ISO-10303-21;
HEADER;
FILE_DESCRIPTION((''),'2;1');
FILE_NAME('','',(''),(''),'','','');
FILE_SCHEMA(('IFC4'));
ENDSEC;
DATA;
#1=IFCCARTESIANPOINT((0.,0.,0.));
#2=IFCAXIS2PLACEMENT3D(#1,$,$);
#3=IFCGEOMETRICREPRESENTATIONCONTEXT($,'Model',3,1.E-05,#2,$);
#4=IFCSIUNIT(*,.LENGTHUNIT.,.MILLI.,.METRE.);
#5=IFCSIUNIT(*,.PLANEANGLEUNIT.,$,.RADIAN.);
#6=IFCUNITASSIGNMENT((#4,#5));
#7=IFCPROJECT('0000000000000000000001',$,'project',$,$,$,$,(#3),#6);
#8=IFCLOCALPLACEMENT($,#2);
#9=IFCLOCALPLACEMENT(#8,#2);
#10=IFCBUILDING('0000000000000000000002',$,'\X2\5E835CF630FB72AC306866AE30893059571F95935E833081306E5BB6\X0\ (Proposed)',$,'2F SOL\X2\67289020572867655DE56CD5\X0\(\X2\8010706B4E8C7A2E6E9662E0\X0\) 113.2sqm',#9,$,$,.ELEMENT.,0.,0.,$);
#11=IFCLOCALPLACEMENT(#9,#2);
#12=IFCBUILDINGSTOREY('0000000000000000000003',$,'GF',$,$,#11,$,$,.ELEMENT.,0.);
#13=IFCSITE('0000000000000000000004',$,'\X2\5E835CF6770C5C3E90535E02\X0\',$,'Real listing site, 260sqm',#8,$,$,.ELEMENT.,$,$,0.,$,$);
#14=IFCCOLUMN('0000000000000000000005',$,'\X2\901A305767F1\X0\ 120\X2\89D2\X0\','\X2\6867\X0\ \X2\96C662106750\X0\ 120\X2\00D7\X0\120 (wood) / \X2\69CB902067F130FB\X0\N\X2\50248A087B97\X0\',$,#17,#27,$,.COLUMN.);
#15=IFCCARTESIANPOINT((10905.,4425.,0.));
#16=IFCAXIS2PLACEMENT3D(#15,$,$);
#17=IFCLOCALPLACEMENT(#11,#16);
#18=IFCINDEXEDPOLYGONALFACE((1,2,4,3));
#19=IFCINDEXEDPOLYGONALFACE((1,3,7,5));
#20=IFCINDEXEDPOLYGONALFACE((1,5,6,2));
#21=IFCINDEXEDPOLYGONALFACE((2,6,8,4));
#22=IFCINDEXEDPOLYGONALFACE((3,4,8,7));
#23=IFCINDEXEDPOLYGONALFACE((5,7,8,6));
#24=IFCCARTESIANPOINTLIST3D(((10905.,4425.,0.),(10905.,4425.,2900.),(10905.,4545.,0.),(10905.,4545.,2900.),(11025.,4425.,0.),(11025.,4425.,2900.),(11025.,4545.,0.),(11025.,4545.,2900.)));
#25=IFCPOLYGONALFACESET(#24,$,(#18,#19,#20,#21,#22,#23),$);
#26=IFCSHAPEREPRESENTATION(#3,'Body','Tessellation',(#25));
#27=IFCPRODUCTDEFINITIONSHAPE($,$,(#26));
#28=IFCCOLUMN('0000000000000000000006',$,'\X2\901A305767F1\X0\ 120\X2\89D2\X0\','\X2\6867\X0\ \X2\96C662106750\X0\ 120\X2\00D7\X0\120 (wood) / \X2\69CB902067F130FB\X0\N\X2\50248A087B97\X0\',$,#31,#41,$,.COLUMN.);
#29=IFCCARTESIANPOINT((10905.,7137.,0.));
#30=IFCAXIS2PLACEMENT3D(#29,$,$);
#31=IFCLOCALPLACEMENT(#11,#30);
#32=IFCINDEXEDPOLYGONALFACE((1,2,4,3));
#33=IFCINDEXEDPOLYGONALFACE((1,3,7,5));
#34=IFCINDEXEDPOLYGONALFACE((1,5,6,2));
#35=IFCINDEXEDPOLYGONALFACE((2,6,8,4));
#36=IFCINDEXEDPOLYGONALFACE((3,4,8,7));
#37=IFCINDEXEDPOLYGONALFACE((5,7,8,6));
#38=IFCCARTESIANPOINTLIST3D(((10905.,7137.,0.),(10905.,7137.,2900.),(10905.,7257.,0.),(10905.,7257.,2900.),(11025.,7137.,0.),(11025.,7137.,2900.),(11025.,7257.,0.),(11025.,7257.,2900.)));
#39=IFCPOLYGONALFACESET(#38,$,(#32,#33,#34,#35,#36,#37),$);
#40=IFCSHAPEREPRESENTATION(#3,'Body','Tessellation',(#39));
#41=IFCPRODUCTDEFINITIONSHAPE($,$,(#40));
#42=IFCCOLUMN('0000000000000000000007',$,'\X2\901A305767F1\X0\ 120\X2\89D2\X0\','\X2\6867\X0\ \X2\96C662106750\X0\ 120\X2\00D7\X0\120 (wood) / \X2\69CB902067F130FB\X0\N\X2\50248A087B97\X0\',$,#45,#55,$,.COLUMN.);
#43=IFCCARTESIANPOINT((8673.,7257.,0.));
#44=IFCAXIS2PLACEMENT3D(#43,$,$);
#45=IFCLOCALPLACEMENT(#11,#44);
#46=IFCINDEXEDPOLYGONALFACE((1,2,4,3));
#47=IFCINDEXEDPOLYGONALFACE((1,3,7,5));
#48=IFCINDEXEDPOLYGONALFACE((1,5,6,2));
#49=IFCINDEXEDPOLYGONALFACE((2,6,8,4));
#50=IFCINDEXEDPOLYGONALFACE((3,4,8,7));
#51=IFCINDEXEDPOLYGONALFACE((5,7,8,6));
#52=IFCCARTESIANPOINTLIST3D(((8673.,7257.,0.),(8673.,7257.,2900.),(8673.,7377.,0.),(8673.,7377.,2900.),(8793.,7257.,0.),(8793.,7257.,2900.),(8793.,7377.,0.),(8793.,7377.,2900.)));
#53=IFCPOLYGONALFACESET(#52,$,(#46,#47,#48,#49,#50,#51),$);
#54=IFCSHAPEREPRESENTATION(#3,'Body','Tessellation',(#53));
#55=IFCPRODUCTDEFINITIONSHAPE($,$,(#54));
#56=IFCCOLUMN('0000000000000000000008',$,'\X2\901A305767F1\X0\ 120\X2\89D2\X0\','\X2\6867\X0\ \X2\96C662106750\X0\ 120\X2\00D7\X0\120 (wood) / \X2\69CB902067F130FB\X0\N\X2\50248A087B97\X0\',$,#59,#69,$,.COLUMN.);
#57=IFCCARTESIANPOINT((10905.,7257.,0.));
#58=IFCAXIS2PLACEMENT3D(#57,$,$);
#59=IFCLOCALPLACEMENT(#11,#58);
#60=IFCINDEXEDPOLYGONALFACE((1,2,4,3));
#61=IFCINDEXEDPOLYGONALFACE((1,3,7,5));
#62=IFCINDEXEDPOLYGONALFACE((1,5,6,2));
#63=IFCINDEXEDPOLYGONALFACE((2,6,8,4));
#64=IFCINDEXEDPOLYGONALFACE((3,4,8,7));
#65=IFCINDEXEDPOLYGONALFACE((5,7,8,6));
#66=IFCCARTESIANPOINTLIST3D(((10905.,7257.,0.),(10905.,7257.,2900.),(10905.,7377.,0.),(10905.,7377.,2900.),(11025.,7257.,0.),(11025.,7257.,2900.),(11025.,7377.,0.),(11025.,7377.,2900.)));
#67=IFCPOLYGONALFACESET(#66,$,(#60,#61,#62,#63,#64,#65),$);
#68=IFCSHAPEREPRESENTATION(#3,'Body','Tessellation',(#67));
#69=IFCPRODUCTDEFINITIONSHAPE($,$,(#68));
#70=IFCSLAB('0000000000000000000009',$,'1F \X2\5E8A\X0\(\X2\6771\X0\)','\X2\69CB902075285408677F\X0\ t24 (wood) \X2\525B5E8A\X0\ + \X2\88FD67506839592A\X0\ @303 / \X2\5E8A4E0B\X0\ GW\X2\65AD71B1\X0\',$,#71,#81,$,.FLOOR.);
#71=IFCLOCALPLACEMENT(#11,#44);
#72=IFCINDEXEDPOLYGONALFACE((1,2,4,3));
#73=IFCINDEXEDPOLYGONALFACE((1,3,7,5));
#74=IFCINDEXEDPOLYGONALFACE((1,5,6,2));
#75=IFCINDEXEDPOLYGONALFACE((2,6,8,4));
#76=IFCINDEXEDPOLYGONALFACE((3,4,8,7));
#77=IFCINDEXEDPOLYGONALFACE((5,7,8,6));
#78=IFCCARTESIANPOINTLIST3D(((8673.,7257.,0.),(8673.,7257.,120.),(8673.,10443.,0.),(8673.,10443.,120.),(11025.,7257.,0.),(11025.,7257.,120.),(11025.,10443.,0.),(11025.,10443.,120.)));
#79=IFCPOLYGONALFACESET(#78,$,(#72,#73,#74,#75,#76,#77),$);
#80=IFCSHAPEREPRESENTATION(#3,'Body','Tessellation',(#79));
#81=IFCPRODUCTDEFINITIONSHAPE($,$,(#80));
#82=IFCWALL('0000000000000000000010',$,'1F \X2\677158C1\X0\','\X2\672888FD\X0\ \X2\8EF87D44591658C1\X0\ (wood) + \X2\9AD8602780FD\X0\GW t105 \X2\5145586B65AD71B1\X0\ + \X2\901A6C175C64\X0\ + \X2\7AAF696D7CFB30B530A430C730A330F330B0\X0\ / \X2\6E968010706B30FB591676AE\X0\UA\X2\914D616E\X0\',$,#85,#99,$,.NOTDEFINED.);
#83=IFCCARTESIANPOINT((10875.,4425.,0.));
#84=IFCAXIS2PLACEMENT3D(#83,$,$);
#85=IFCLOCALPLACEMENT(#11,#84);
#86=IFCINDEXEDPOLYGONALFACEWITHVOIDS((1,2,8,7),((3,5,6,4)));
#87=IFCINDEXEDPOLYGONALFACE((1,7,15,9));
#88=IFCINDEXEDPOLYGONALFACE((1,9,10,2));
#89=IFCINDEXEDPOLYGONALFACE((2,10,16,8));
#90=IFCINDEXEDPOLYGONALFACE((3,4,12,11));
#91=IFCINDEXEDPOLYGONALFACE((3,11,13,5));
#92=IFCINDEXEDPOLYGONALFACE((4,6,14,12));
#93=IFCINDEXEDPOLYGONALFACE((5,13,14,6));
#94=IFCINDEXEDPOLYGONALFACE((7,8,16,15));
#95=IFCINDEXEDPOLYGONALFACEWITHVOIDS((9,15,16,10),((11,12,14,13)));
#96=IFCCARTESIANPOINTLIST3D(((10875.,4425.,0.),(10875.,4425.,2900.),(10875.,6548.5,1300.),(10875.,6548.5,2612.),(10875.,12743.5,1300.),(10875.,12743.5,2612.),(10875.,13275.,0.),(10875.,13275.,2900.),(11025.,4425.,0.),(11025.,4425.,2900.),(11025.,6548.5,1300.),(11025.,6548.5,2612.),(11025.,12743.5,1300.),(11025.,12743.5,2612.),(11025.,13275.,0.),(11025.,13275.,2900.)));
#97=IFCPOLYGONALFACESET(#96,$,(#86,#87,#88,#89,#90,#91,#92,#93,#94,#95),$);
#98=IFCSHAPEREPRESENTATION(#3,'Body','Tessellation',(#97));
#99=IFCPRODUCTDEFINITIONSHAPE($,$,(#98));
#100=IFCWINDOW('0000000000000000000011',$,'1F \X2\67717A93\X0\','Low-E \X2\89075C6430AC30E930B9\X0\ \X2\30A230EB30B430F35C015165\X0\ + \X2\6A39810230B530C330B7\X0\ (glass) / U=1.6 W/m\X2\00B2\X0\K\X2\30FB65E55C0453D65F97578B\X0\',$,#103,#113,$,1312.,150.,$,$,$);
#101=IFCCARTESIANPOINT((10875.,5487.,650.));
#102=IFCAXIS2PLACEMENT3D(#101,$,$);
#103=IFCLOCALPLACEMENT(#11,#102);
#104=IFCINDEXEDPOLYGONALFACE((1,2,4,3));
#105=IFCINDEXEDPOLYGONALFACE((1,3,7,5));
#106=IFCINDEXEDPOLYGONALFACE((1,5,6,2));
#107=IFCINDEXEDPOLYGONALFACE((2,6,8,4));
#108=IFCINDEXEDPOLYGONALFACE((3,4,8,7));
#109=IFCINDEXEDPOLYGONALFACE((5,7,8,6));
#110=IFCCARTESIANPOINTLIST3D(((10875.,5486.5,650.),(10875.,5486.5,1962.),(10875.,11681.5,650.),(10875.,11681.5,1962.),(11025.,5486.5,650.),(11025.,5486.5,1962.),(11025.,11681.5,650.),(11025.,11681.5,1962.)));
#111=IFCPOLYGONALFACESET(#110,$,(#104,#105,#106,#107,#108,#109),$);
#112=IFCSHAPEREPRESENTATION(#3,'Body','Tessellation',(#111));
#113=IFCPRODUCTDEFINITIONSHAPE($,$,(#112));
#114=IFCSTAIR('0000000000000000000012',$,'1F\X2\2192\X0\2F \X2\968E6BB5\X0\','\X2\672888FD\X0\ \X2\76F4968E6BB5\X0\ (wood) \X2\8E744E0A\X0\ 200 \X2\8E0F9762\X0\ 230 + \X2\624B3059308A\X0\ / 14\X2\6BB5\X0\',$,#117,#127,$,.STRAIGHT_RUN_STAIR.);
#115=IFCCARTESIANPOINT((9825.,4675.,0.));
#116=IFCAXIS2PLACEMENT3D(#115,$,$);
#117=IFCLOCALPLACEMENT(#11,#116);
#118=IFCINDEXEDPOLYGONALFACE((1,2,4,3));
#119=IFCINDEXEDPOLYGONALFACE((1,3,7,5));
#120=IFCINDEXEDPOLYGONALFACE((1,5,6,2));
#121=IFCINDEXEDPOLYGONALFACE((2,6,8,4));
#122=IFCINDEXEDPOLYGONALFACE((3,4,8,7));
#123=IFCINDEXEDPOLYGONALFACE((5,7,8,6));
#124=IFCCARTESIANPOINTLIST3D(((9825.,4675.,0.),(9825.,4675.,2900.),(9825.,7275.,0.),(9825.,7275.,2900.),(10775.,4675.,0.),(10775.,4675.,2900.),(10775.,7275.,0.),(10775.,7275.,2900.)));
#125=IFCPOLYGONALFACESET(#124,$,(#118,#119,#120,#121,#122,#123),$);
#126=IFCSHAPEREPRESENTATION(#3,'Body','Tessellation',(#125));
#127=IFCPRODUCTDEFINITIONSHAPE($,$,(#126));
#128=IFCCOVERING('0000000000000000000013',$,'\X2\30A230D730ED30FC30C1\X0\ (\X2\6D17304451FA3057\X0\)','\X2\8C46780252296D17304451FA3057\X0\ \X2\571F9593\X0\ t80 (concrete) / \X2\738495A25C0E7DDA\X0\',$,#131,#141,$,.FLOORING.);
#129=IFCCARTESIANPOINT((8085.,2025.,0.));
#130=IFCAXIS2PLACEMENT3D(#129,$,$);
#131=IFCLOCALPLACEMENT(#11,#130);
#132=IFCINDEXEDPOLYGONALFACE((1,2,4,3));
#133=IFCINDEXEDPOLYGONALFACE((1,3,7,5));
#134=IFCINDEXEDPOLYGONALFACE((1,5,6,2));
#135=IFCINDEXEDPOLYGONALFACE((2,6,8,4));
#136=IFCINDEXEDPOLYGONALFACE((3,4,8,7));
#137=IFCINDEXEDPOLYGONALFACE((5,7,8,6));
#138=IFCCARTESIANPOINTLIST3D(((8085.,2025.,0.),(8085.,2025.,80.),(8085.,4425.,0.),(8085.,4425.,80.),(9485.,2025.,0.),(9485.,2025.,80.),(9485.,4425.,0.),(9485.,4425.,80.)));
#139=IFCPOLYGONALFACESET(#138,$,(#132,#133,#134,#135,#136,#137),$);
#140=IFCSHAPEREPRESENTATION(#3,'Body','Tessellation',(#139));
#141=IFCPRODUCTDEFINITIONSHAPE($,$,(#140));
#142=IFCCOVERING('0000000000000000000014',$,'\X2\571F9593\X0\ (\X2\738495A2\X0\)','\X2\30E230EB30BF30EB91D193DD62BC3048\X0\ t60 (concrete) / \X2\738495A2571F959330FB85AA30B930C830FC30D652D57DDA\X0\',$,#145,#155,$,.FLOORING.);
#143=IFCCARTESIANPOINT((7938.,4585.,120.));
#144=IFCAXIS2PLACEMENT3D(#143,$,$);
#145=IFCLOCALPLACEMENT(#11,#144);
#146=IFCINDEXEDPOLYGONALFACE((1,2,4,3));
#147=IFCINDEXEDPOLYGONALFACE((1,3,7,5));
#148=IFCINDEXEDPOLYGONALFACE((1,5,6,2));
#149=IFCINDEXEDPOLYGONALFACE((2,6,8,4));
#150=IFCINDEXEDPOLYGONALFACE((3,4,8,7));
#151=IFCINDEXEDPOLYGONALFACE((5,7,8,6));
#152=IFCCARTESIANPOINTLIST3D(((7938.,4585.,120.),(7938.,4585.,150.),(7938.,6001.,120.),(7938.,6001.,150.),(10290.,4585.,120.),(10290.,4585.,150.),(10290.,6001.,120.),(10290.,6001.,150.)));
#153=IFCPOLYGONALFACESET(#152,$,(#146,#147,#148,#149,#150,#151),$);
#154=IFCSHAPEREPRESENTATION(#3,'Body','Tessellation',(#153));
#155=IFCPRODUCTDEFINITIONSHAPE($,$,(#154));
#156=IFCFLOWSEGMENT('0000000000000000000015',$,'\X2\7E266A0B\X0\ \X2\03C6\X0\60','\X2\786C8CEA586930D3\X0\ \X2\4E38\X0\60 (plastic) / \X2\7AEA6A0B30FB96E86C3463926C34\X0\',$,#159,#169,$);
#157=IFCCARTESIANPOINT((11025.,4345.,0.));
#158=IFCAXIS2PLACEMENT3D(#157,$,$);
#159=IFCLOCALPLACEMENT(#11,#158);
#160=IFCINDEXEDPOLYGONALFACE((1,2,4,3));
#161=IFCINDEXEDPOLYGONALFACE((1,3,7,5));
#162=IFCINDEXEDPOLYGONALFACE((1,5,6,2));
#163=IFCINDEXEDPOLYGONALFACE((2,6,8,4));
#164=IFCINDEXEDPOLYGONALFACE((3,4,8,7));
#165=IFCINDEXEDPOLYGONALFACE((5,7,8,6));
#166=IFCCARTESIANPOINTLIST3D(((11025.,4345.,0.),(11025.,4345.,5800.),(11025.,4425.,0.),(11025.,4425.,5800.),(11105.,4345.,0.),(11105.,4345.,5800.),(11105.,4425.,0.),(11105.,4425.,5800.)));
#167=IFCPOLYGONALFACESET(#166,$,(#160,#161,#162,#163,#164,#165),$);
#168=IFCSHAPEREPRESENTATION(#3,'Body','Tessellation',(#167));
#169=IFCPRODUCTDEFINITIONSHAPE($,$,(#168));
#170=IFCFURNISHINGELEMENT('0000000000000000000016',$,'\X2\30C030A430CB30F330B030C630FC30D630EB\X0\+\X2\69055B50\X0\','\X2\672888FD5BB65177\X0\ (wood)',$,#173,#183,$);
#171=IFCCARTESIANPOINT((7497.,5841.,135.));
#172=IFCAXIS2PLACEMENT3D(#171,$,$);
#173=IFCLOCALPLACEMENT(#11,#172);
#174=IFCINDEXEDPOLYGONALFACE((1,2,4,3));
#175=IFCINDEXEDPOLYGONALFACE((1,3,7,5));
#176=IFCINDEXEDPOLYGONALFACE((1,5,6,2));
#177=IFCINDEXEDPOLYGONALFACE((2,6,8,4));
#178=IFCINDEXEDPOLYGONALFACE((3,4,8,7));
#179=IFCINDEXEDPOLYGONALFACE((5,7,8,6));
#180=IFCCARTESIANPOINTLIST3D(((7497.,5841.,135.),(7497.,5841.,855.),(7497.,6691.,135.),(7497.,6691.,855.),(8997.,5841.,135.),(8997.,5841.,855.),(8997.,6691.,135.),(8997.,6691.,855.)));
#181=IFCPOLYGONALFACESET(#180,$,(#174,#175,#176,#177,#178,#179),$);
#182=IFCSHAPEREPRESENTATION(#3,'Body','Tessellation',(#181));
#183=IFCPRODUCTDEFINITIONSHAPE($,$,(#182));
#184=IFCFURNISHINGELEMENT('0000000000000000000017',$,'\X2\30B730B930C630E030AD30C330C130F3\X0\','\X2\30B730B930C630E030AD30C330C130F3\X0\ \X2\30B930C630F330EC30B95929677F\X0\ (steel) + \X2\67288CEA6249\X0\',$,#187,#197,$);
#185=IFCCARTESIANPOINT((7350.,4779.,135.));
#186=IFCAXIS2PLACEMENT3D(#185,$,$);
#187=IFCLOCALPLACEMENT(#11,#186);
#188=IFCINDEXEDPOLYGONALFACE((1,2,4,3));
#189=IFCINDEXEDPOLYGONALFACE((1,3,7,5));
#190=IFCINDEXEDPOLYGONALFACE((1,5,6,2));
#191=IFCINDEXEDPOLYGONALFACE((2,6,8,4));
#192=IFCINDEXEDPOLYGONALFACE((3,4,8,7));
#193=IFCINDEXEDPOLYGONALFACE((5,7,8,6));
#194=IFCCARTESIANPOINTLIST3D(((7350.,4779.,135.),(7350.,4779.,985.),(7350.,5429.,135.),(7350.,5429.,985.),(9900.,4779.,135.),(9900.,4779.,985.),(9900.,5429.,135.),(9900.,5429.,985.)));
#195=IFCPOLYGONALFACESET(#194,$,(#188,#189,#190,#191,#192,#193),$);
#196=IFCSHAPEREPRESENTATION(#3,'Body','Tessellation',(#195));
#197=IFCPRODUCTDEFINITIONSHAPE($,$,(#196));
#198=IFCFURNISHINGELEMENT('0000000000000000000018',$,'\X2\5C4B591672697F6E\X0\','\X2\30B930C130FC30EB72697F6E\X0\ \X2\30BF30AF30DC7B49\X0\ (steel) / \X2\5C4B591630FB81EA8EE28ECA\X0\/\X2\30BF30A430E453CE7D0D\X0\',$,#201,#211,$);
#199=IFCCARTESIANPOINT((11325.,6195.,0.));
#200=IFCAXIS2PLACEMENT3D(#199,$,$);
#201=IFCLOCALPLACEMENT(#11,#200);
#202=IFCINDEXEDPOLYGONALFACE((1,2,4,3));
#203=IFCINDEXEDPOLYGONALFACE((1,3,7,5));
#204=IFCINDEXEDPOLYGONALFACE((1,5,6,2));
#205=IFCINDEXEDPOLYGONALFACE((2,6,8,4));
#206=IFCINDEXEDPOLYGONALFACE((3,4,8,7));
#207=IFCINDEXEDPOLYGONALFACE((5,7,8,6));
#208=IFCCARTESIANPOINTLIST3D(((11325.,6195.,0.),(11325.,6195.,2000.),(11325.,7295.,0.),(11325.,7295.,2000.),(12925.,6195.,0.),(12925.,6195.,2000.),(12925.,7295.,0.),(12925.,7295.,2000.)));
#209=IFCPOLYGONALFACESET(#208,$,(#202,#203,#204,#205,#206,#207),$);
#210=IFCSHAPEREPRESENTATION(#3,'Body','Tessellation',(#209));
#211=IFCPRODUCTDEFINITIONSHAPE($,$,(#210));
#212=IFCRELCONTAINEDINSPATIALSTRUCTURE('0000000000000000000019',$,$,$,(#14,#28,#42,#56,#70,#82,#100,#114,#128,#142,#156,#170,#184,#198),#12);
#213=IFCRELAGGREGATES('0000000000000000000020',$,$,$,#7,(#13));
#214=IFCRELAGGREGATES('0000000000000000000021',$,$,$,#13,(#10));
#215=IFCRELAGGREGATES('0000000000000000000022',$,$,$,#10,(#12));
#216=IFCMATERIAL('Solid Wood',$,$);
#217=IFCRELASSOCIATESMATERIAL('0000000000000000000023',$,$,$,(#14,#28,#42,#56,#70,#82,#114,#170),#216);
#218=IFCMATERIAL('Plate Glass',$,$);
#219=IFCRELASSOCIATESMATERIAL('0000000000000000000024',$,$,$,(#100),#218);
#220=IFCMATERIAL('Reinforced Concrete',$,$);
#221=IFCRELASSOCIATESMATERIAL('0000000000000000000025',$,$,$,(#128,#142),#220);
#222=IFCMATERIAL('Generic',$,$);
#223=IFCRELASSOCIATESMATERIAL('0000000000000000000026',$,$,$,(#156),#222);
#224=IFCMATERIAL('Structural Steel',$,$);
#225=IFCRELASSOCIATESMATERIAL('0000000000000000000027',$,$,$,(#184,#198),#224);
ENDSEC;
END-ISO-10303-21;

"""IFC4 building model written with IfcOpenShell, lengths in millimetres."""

from ifc_helpers import new_model, si_unit, frame, frame_2d, origin, place, context, project, spatial, rectangle, extrude, material, element, fill, save


model = new_model("IFC4")

# Units and contexts
model_context = context("Model", 3, precision=1e-05, world=origin())
ifc_project = project(units=[si_unit("LENGTHUNIT", "METRE", prefix="MILLI"), si_unit("PLANEANGLEUNIT", "RADIAN")], contexts=[model_context])

# Site, building, storey
site_placement = place(None, origin())
site = spatial("IfcSite", under=ifc_project, at=site_placement, Name="広島県尾道市", ObjectType="Real listing site, 260sqm", CompositionType="ELEMENT", RefElevation=0.0)
building_placement = place(site_placement, origin())
building = spatial("IfcBuilding", under=site, at=building_placement, Name="広島・犬と暮らす土間広めの家 (Proposed)", ObjectType="2F SOL木造在来工法(耐火二種準拠) 113.2sqm", CompositionType="ELEMENT", ElevationOfRefHeight=0.0, ElevationOfTerrain=0.0)
storey_placement = place(building_placement, origin())
storey = spatial("IfcBuildingStorey", under=building, at=storey_placement, Name="GF", CompositionType="ELEMENT", Elevation=0.0)

# Columns
ifc_material_1 = material(Name="Solid Wood")
column_1_placement = place(storey_placement, frame((10905.0, 4425.0, 0.0)))
element("IfcColumn", 1, at=column_1_placement, inside=storey, material=ifc_material_1, Name="通し柱 120角", Description="桧 集成材 120×120 (wood) / 構造柱・N値計算", PredefinedType="COLUMN", context=model_context, shape_type="SweptSolid", body=[
    extrude(rectangle(XDim=120.0, YDim=120.0, at=frame_2d((60.0, 60.0))), frame((10905.0, 4425.0, 0.0)), (0.0, 0.0, 1.0), 2900.0),
])
column_2_placement = place(storey_placement, frame((10905.0, 7137.0, 0.0)))
element("IfcColumn", 2, at=column_2_placement, inside=storey, material=ifc_material_1, Name="通し柱 120角", Description="桧 集成材 120×120 (wood) / 構造柱・N値計算", PredefinedType="COLUMN", context=model_context, shape_type="SweptSolid", body=[
    extrude(rectangle(XDim=120.0, YDim=120.0, at=frame_2d((60.0, 60.0))), frame((10905.0, 7137.0, 0.0)), (0.0, 0.0, 1.0), 2900.0),
])
column_3_placement = place(storey_placement, frame((8673.0, 7257.0, 0.0)))
element("IfcColumn", 3, at=column_3_placement, inside=storey, material=ifc_material_1, Name="通し柱 120角", Description="桧 集成材 120×120 (wood) / 構造柱・N値計算", PredefinedType="COLUMN", context=model_context, shape_type="SweptSolid", body=[
    extrude(rectangle(XDim=120.0, YDim=120.0, at=frame_2d((60.0, 60.0))), frame((8673.0, 7257.0, 0.0)), (0.0, 0.0, 1.0), 2900.0),
])
column_4_placement = place(storey_placement, frame((10905.0, 7257.0, 0.0)))
element("IfcColumn", 4, at=column_4_placement, inside=storey, material=ifc_material_1, Name="通し柱 120角", Description="桧 集成材 120×120 (wood) / 構造柱・N値計算", PredefinedType="COLUMN", context=model_context, shape_type="SweptSolid", body=[
    extrude(rectangle(XDim=120.0, YDim=120.0, at=frame_2d((60.0, 60.0))), frame((10905.0, 7257.0, 0.0)), (0.0, 0.0, 1.0), 2900.0),
])

# Slab
slab_placement = place(storey_placement, frame((8673.0, 7257.0, 0.0)))
element("IfcSlab", 5, at=slab_placement, inside=storey, material=ifc_material_1, Name="1F 床(東)", Description="構造用合板 t24 (wood) 剛床 + 製材根太 @303 / 床下 GW断熱", PredefinedType="FLOOR", context=model_context, shape_type="SweptSolid", body=[
    extrude(rectangle(XDim=2352.0, YDim=3186.0, at=frame_2d((1176.0, 1593.0))), frame((8673.0, 7257.0, 0.0)), (0.0, 0.0, 1.0), 120.0),
])

# Wall, opening, window
wall_1_placement = place(storey_placement, frame((10875.0, 4425.0, 0.0)))
wall_1 = element("IfcWall", 6, at=wall_1_placement, inside=storey, material=ifc_material_1, Name="1F 東壁", Description="木製 軸組外壁 (wood) + 高性能GW t105 充填断熱 + 通気層 + 窯業系サイディング / 準耐火・外皮UA配慮", PredefinedType="NOTDEFINED", context=model_context, shape_type="SweptSolid", body=[
    extrude(rectangle(XDim=150.0, YDim=8850.0, at=frame_2d((75.0, 4425.0))), frame((10875.0, 4425.0, 0.0)), (0.0, 0.0, 1.0), 2900.0),
])
opening_placement = place(storey_placement, frame((10875.0, 5487.0, 650.0)))
opening = element("IfcOpeningElement", 7, at=opening_placement, cuts=wall_1, PredefinedType="NOTDEFINED", context=model_context, shape_type="SweptSolid", body=[
    extrude(rectangle(XDim=150.0, YDim=6195.0, at=frame_2d((75.0, 3097.0))), frame((10875.0, 5487.0, 650.0)), (0.0, 0.0, 1.0), 1312.0),
])
ifc_material_2 = material(Name="Plate Glass")
window_placement = place(storey_placement, frame((10875.0, 5487.0, 650.0)))
window = element("IfcWindow", 8, at=window_placement, inside=storey, material=ifc_material_2, Name="1F 東窓", Description="Low-E 複層ガラス アルゴン封入 + 樹脂サッシ (glass) / U=1.6 W/m²K・日射取得型", OverallHeight=1312.0, OverallWidth=150.0, context=model_context, shape_type="SweptSolid", body=[
    extrude(rectangle(XDim=150.0, YDim=6195.0, at=frame_2d((75.0, 3097.0))), frame((10875.0, 5487.0, 650.0)), (0.0, 0.0, 1.0), 1312.0),
])
fill(opening, window)

# Stair
stair_placement = place(storey_placement, frame((9825.0, 4675.0, 0.0)))
element("IfcStair", 9, at=stair_placement, inside=storey, material=ifc_material_1, Name="1F→2F 階段", Description="木製 直階段 (wood) 蹴上 200 踏面 230 + 手すり / 14段", PredefinedType="STRAIGHT_RUN_STAIR", context=model_context, shape_type="SweptSolid", body=[
    extrude(rectangle(XDim=950.0, YDim=2600.0, at=frame_2d((475.0, 1300.0))), frame((9825.0, 4675.0, 0.0)), (0.0, 0.0, 1.0), 2900.0),
])

# Coverings
ifc_material_3 = material(Name="Reinforced Concrete")
covering_1_placement = place(storey_placement, frame((8085.0, 2025.0, 0.0)))
element("IfcCovering", 10, at=covering_1_placement, inside=storey, material=ifc_material_3, Name="アプローチ (洗い出し)", Description="豆砂利洗い出し 土間 t80 (concrete) / 玄関導線", PredefinedType="FLOORING", context=model_context, shape_type="SweptSolid", body=[
    extrude(rectangle(XDim=1400.0, YDim=2400.0, at=frame_2d((700.0, 1200.0))), frame((8085.0, 2025.0, 0.0)), (0.0, 0.0, 1.0), 80.0),
])
covering_2_placement = place(storey_placement, frame((7938.0, 4585.0, 120.0)))
element("IfcCovering", 11, at=covering_2_placement, inside=storey, material=ifc_material_3, Name="土間 (玄関)", Description="モルタル金鏝押え t60 (concrete) / 玄関土間・薪ストーブ動線", PredefinedType="FLOORING", context=model_context, shape_type="SweptSolid", body=[
    extrude(rectangle(XDim=2352.0, YDim=1416.0, at=frame_2d((1176.0, 708.0))), frame((7938.0, 4585.0, 120.0)), (0.0, 0.0, 1.0), 30.0),
])

# Flow segment
ifc_material_4 = material(Name="Generic")
flow_segment_placement = place(storey_placement, frame((11025.0, 4345.0, 0.0)))
element("IfcFlowSegment", 12, at=flow_segment_placement, inside=storey, material=ifc_material_4, Name="縦樋 φ60", Description="硬質塩ビ 丸60 (plastic) / 竪樋・雨水排水", context=model_context, shape_type="SweptSolid", body=[
    extrude(rectangle(XDim=80.0, YDim=80.0, at=frame_2d((40.0, 40.0))), frame((11025.0, 4345.0, 0.0)), (0.0, 0.0, 1.0), 5800.0),
])

# Furnishing elements
furnishing_1_placement = place(storey_placement, frame((7497.0, 5841.0, 135.0)))
element("IfcFurnishingElement", 13, at=furnishing_1_placement, inside=storey, material=ifc_material_1, Name="ダイニングテーブル+椅子", Description="木製家具 (wood)", context=model_context, shape_type="SweptSolid", body=[
    extrude(rectangle(XDim=1500.0, YDim=850.0, at=frame_2d((750.0, 425.0))), frame((7497.0, 5841.0, 135.0)), (0.0, 0.0, 1.0), 720.0),
])
ifc_material_5 = material(Name="Structural Steel")
furnishing_2_placement = place(storey_placement, frame((7350.0, 4779.0, 135.0)))
element("IfcFurnishingElement", 14, at=furnishing_2_placement, inside=storey, material=ifc_material_5, Name="システムキッチン", Description="システムキッチン ステンレス天板 (steel) + 木質扉", context=model_context, shape_type="SweptSolid", body=[
    extrude(rectangle(XDim=2550.0, YDim=650.0, at=frame_2d((1275.0, 325.0))), frame((7350.0, 4779.0, 135.0)), (0.0, 0.0, 1.0), 850.0),
])
furnishing_3_placement = place(storey_placement, frame((11325.0, 6195.0, 0.0)))
element("IfcFurnishingElement", 15, at=furnishing_3_placement, inside=storey, material=ifc_material_5, Name="屋外物置", Description="スチール物置 タクボ等 (steel) / 屋外・自転車/タイヤ収納", context=model_context, shape_type="SweptSolid", body=[
    extrude(rectangle(XDim=1600.0, YDim=1100.0, at=frame_2d((800.0, 550.0))), frame((11325.0, 6195.0, 0.0)), (0.0, 0.0, 1.0), 2000.0),
])

save(model, "model.ifc")
